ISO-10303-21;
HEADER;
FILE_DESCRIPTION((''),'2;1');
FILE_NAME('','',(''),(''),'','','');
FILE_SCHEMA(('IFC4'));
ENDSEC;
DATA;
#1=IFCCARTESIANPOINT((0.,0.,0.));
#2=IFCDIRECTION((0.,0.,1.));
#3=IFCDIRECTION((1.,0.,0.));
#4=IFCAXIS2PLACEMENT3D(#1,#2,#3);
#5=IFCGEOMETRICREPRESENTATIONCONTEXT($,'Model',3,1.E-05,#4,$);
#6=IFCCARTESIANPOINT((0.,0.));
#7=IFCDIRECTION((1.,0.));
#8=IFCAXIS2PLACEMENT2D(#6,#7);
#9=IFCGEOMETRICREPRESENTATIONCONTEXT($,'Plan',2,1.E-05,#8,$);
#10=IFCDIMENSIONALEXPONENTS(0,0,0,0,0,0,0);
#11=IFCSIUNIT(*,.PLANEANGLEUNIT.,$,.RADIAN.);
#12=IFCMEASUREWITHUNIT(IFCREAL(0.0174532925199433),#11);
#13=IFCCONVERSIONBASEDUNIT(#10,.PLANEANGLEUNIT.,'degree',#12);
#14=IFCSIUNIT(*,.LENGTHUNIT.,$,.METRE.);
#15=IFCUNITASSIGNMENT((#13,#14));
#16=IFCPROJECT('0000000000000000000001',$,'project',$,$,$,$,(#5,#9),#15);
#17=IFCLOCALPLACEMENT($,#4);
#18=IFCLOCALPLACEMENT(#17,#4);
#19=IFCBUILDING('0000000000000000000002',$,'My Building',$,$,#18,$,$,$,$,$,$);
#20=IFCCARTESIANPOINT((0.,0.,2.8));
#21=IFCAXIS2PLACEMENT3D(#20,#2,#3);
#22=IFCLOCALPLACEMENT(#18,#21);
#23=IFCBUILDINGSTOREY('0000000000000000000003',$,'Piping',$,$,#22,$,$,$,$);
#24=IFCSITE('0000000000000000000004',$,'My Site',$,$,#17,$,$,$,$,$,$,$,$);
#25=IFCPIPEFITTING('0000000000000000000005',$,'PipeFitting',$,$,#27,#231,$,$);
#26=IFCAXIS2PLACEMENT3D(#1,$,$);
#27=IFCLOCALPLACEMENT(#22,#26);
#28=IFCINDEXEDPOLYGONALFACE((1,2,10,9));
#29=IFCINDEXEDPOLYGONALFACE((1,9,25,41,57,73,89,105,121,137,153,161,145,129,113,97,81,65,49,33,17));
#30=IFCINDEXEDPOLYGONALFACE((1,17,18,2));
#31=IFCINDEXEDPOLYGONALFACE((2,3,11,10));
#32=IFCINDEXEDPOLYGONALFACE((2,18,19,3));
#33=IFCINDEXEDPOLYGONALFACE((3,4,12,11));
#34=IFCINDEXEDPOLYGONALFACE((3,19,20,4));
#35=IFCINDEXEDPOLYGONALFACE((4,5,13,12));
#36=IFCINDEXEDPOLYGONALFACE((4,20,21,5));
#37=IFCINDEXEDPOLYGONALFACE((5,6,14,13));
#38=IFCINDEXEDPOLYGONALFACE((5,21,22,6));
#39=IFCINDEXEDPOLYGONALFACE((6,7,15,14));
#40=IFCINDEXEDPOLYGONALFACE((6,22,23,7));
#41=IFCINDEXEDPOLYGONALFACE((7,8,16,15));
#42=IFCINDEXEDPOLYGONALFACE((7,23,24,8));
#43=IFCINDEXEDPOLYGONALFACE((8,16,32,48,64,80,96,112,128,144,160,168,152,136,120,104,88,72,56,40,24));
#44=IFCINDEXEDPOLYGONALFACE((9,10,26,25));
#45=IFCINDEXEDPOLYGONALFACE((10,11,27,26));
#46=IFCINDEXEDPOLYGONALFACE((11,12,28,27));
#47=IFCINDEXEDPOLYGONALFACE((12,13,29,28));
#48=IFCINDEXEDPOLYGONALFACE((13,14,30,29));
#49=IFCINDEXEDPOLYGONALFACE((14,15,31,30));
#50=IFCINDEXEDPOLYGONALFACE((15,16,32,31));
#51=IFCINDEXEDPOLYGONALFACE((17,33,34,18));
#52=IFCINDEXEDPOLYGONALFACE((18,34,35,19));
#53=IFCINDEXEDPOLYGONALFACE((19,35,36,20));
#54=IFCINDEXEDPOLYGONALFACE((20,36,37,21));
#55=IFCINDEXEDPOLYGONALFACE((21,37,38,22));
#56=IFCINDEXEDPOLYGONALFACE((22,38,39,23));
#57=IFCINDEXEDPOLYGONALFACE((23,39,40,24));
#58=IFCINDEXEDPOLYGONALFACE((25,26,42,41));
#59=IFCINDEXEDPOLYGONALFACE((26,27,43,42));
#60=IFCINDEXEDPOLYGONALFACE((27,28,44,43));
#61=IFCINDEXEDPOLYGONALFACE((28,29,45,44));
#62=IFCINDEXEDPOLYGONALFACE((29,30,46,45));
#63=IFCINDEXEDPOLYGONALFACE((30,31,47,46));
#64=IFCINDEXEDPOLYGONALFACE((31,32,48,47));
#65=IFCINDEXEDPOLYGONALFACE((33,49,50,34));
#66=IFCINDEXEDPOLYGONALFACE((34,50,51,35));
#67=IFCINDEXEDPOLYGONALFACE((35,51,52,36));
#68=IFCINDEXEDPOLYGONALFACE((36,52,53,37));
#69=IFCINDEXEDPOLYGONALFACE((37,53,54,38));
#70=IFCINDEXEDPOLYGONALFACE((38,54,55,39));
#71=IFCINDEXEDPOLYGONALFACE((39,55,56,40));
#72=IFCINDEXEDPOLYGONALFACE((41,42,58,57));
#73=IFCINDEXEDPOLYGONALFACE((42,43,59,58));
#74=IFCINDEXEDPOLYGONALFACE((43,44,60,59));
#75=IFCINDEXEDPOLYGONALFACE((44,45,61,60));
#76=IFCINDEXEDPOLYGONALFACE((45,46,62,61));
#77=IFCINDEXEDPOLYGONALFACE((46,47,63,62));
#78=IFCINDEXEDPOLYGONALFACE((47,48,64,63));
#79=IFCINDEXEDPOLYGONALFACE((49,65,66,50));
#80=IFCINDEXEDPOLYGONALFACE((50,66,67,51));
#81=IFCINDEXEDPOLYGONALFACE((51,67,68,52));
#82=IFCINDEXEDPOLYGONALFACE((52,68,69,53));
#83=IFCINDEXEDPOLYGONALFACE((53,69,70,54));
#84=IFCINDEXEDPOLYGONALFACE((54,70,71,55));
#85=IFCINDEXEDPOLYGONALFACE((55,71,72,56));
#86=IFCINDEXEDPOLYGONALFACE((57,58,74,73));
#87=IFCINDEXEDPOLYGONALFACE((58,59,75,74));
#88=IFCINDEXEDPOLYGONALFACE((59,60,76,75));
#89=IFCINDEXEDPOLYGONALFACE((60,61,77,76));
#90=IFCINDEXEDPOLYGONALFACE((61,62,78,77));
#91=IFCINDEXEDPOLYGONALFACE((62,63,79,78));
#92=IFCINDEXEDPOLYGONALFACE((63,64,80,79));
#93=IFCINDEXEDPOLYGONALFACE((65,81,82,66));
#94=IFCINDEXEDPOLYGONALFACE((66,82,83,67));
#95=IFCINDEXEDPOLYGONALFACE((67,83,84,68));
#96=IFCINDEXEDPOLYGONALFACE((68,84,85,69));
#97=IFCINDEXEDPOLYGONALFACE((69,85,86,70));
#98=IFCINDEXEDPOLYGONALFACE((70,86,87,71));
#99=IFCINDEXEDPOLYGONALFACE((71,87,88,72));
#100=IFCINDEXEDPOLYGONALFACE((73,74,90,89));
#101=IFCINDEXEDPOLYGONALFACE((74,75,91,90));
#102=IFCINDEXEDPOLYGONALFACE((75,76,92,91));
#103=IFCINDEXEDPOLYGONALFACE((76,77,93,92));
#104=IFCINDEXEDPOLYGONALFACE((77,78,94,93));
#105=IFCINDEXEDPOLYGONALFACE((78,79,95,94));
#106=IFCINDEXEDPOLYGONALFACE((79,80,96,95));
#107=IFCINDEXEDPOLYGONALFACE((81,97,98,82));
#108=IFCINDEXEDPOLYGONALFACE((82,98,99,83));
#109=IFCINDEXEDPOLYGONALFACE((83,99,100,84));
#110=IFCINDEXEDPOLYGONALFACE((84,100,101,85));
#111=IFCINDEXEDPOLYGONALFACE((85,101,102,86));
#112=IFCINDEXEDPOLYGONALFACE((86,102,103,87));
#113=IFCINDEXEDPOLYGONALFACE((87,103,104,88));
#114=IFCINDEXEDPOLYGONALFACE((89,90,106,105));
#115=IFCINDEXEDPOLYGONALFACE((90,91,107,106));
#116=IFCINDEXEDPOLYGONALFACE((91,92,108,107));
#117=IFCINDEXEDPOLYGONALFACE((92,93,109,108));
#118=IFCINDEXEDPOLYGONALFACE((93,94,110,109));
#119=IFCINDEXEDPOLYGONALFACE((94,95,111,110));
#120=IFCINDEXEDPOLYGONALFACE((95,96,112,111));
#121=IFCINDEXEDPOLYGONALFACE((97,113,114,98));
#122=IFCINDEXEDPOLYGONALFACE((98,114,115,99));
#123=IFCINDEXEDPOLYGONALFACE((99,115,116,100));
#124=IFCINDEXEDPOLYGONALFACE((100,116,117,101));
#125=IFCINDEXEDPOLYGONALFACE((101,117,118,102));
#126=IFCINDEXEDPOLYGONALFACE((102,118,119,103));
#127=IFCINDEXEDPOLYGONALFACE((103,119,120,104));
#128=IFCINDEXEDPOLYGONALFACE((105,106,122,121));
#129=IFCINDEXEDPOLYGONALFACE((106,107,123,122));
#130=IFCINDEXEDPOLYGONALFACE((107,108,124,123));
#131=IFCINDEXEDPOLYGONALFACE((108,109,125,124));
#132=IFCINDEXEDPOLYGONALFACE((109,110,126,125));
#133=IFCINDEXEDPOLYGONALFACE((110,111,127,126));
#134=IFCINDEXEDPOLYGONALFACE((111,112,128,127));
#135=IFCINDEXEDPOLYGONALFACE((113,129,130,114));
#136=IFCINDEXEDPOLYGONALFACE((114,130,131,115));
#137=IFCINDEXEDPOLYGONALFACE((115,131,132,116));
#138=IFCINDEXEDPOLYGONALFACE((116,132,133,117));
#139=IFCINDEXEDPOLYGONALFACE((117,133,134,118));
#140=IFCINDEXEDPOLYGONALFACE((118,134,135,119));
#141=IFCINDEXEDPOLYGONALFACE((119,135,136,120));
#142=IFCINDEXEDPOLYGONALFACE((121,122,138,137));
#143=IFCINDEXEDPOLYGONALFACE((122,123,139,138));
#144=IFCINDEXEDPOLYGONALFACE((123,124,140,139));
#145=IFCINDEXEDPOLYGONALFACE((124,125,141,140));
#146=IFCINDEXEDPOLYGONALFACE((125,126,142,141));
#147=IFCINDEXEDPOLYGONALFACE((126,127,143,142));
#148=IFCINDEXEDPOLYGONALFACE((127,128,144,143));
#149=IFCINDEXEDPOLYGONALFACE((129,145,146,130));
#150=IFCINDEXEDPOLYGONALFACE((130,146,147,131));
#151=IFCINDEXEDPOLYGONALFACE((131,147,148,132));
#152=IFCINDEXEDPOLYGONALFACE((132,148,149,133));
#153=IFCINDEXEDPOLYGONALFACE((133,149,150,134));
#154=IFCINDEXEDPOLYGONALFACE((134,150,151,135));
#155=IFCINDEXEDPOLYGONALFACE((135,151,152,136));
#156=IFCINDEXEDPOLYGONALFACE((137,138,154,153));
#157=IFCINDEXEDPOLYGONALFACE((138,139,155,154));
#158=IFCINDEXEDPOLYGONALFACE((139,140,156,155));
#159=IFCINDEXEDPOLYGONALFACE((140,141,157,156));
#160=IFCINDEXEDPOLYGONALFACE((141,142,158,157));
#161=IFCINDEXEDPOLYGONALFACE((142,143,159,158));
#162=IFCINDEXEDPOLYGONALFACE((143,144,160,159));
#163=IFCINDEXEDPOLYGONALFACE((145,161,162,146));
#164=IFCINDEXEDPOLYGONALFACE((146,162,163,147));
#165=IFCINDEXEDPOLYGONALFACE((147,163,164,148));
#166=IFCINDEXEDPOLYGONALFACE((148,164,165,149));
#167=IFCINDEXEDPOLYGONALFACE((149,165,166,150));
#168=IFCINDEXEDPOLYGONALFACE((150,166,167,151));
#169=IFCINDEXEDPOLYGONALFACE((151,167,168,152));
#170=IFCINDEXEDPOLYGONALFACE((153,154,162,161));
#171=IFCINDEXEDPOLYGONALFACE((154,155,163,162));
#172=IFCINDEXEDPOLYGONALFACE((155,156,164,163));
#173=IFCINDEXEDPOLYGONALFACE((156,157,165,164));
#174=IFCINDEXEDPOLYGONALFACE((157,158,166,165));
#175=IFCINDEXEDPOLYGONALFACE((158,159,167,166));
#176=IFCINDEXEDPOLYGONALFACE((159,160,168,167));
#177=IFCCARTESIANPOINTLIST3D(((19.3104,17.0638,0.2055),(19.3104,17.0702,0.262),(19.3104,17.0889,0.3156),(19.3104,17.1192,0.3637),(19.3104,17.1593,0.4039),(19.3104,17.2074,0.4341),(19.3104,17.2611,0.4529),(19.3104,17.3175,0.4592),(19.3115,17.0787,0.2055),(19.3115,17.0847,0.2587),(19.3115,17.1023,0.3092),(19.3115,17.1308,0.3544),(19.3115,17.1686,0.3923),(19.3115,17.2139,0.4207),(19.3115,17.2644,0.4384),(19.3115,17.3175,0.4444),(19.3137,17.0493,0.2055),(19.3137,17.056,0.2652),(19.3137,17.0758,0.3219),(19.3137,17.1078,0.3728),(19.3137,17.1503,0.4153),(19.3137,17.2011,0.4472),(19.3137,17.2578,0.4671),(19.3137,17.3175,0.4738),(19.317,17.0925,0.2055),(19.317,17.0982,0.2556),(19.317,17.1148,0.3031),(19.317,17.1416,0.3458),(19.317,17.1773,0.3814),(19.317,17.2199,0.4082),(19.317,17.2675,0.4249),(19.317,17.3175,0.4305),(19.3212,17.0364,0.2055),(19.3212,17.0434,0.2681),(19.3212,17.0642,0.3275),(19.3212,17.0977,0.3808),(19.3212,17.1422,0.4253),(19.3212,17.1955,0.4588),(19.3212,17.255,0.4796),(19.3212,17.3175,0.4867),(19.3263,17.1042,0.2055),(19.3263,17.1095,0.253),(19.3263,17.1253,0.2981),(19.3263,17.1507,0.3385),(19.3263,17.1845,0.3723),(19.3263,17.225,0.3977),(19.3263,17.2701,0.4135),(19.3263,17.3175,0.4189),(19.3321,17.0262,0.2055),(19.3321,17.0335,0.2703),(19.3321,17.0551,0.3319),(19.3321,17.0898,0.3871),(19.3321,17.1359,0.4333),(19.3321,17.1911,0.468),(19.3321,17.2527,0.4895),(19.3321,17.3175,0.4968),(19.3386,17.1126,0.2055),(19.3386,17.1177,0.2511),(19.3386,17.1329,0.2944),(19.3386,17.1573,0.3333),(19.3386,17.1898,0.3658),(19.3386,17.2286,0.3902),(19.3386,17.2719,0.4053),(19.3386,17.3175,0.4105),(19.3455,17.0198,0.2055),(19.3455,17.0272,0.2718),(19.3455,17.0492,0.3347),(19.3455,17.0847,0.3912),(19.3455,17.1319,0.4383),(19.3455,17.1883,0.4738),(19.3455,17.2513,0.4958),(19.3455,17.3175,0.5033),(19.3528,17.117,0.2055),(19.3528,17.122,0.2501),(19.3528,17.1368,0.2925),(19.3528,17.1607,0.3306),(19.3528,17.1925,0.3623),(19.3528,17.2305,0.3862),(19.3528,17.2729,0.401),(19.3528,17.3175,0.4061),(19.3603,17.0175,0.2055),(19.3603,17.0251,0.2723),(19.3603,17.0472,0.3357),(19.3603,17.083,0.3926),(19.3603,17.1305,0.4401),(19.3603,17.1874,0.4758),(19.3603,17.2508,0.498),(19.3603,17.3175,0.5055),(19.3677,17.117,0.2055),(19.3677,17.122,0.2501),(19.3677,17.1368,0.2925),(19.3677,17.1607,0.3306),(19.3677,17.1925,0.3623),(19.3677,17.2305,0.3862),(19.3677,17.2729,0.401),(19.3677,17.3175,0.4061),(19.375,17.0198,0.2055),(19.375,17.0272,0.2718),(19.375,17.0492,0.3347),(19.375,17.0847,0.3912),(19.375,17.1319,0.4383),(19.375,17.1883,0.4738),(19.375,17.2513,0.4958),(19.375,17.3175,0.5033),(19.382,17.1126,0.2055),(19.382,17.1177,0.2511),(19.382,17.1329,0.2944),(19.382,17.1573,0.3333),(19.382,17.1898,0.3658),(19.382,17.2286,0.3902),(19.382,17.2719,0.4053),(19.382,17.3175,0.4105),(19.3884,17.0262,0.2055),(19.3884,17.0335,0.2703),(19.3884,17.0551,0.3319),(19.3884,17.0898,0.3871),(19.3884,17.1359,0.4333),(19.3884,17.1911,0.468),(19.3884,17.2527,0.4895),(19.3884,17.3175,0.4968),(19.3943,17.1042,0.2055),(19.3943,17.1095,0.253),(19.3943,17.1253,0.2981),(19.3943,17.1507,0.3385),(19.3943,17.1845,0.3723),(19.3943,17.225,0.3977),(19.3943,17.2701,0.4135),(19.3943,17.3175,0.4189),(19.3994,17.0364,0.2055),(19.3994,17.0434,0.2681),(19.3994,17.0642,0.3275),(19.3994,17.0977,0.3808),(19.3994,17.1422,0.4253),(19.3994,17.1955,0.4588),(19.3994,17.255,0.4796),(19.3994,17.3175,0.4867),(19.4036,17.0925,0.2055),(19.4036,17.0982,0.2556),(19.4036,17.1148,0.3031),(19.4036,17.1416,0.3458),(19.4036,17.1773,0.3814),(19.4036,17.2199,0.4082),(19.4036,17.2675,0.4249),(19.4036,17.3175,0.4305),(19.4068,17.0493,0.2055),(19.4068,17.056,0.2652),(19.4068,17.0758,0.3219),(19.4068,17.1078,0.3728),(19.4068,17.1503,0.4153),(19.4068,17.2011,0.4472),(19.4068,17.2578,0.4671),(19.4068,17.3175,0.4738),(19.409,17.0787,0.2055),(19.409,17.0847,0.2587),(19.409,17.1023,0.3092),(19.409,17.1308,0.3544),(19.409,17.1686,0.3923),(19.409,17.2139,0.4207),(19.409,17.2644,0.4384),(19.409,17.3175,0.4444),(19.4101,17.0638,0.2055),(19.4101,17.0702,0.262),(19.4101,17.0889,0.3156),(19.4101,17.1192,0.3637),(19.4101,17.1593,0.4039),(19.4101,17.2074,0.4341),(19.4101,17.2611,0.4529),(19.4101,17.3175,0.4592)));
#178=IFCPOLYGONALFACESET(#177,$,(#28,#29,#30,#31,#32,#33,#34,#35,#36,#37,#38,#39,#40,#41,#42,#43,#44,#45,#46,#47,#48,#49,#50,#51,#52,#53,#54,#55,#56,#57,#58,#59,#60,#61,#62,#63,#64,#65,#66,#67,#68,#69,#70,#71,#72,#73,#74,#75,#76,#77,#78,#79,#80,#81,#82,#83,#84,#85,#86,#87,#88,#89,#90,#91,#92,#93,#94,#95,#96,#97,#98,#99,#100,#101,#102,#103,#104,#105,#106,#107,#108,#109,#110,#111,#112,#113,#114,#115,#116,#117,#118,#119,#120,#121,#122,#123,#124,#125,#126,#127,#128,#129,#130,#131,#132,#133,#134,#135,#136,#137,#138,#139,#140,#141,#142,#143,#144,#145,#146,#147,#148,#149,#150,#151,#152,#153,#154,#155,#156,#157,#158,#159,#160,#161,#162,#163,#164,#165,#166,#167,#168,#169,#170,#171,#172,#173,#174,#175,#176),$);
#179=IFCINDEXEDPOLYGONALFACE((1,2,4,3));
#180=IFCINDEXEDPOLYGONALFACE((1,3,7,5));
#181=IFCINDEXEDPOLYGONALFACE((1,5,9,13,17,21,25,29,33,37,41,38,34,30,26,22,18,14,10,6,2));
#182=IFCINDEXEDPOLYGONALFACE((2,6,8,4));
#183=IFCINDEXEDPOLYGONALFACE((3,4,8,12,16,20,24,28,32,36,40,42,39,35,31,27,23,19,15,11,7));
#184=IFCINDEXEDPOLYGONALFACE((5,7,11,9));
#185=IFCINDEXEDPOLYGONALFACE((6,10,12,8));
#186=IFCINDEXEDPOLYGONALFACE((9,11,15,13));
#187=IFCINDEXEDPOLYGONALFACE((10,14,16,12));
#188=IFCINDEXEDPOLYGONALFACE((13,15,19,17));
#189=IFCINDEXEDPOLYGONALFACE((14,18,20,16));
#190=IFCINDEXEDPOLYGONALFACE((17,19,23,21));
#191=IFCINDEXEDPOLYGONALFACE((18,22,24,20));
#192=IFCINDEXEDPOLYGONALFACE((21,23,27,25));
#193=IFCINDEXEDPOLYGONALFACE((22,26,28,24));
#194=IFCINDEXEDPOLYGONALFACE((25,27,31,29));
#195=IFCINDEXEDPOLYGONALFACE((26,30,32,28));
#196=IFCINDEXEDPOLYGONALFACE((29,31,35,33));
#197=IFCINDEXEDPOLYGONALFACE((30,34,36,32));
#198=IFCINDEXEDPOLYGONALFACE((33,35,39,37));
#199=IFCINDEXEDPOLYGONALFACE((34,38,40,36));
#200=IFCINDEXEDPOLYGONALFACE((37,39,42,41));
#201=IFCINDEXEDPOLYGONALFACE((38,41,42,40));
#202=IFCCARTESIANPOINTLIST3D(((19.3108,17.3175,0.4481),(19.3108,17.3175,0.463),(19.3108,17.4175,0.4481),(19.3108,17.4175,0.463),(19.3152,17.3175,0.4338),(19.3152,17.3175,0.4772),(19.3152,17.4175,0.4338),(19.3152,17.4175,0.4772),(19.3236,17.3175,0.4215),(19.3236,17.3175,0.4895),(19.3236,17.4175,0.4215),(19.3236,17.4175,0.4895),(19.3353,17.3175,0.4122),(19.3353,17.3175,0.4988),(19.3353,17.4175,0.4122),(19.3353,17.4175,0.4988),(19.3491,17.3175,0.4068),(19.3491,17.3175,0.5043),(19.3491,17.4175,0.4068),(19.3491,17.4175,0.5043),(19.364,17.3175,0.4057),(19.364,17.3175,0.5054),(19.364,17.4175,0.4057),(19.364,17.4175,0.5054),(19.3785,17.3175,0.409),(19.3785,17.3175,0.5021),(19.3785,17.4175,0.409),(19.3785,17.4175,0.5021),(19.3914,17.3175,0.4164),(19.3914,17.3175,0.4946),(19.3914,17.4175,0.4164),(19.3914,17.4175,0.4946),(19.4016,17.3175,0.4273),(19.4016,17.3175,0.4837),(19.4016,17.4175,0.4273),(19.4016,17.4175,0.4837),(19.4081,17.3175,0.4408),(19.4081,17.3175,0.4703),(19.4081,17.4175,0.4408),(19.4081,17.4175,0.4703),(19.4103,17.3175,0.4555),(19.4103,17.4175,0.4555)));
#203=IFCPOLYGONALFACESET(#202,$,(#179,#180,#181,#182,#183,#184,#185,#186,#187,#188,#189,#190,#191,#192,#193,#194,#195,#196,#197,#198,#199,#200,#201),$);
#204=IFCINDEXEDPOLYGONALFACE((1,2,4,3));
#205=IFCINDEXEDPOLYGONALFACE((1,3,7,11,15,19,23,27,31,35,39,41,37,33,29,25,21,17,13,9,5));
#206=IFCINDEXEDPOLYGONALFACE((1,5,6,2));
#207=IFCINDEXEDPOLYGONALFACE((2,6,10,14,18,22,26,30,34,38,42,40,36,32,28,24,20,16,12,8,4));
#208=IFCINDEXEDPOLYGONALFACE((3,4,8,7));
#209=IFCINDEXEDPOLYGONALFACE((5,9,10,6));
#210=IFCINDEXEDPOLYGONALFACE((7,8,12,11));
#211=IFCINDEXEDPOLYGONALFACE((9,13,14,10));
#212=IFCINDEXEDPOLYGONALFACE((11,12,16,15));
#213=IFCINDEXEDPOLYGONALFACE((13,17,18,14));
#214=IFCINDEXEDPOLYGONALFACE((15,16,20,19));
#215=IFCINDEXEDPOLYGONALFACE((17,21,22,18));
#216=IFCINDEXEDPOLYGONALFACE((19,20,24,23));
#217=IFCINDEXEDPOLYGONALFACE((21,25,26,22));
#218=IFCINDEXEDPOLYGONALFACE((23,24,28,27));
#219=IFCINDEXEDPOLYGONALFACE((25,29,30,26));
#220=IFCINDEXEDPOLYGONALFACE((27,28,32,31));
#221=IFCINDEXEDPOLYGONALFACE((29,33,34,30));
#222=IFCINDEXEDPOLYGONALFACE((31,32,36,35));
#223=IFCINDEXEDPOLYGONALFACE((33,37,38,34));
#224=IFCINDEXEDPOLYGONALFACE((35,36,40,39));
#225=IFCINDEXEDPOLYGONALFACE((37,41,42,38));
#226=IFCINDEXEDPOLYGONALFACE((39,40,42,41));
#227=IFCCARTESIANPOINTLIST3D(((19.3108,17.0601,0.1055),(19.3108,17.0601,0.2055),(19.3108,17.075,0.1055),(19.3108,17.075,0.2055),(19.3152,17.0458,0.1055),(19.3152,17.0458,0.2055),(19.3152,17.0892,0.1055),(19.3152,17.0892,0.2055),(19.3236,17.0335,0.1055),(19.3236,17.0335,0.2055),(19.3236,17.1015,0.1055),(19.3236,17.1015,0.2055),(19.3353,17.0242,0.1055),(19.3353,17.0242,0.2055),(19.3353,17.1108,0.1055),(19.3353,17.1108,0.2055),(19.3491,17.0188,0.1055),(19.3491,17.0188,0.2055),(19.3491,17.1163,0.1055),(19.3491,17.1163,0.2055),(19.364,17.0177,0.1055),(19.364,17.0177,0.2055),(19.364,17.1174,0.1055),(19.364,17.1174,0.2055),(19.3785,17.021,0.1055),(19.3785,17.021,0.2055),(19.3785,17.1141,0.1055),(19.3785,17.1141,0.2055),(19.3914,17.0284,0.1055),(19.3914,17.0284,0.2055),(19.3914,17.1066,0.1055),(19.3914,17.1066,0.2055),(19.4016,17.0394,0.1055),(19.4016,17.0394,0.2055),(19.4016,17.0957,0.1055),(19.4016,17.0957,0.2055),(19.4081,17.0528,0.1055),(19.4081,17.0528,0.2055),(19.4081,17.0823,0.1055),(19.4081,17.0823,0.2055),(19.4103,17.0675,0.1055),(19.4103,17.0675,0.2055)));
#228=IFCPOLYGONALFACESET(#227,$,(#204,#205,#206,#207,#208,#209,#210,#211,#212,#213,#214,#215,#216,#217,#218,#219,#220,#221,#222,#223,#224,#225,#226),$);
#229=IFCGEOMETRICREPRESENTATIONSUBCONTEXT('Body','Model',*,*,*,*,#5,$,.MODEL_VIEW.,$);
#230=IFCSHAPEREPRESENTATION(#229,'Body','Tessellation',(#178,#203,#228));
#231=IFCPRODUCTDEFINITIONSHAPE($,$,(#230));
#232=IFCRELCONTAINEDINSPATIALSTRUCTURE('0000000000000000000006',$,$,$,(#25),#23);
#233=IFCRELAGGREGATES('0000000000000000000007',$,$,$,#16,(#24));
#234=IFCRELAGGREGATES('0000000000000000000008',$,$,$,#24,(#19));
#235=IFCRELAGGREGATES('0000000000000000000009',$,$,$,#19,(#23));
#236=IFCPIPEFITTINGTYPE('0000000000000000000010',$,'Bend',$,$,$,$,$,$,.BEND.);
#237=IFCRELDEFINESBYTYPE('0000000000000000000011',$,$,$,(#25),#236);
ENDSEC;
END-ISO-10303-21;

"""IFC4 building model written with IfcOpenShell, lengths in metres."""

from ifc_helpers import new_model, entity, si_unit, converted_unit, frame, origin_with_axes, origin_2d_with_axis, place, context, subcontext, project, spatial, circle, extrude, source, transform, mapped, type_object, type_shapes, element, save


model = new_model("IFC4")

# Units and contexts
model_context = context("Model", 3, precision=1e-05, world=origin_with_axes())
plan_context = context("Plan", 2, precision=1e-05, world=origin_2d_with_axis())
body_context = subcontext(model_context, "Body", "Model", "MODEL_VIEW")
ifc_project = project(units=[converted_unit("PLANEANGLEUNIT", "degree", entity("IfcReal", 0.0174532925199433), si_unit("PLANEANGLEUNIT", "RADIAN"), dimensions=[0, 0, 0, 0, 0, 0, 0]), si_unit("LENGTHUNIT", "METRE")], contexts=[model_context, plan_context])

# Site, building, storey
site_placement = place(None, origin_with_axes())
site = spatial("IfcSite", under=ifc_project, at=site_placement, Name="My Site")
building_placement = place(site_placement, origin_with_axes())
building = spatial("IfcBuilding", under=site, at=building_placement, Name="My Building")
storey_placement = place(building_placement, frame((0.0, 0.0, 2.8), z_axis=(0.0, 0.0, 1.0), x_axis=(1.0, 0.0, 0.0)))
storey = spatial("IfcBuildingStorey", under=building, at=storey_placement, Name="Piping")

# Pipe fitting
pipe_fitting_type_1 = type_object("IfcPipeFittingType", Name="Bend", PredefinedType="BEND")
shared_shape_1 = source(origin_with_axes(), body_context, "Body", "SolidModel", [
    entity("IfcSweptDiskSolid", entity("IfcIndexedPolyCurve", entity("IfcCartesianPointList3D", [[0.0, 0.0, 0.1], [0.0, -0.0732, 0.2768], [0.0, -0.25, 0.35]]), [entity("IfcArcIndex", [1, 2, 3])]), 0.05),
    extrude(circle(Radius=0.05), origin_with_axes(), (0.0, 0.0, 1.0), 0.1),
    extrude(circle(Radius=0.05), frame((0.0, -0.25, 0.35), z_axis=(0.0, -1.0, 0.0), x_axis=(1.0, 0.0, 0.0)), (0.0, 0.0, 1.0), 0.1),
])
type_shapes(pipe_fitting_type_1, [shared_shape_1])
for number, where, z_axis, x_axis, name in (
    (1, (19.3603, 17.4175, 0.4555), (0.0, -1.0, 0.0), (1.0, 0.0, 0.0), "PipeFitting"),
):
    element("IfcPipeFitting", number, at=place(storey_placement, frame(where, z_axis=z_axis, x_axis=x_axis)), inside=storey, type_object=pipe_fitting_type_1, Name=name, context=body_context, shape_type="MappedRepresentation", body=[
        mapped(shared_shape_1, transform((0.0, 0.0, 0.0), x_axis=(1.0, 0.0, 0.0), y_axis=(0.0, 1.0, 0.0), z_axis=(0.0, 0.0, 1.0), scale=1.0)),
    ])

save(model, "model.ifc")
